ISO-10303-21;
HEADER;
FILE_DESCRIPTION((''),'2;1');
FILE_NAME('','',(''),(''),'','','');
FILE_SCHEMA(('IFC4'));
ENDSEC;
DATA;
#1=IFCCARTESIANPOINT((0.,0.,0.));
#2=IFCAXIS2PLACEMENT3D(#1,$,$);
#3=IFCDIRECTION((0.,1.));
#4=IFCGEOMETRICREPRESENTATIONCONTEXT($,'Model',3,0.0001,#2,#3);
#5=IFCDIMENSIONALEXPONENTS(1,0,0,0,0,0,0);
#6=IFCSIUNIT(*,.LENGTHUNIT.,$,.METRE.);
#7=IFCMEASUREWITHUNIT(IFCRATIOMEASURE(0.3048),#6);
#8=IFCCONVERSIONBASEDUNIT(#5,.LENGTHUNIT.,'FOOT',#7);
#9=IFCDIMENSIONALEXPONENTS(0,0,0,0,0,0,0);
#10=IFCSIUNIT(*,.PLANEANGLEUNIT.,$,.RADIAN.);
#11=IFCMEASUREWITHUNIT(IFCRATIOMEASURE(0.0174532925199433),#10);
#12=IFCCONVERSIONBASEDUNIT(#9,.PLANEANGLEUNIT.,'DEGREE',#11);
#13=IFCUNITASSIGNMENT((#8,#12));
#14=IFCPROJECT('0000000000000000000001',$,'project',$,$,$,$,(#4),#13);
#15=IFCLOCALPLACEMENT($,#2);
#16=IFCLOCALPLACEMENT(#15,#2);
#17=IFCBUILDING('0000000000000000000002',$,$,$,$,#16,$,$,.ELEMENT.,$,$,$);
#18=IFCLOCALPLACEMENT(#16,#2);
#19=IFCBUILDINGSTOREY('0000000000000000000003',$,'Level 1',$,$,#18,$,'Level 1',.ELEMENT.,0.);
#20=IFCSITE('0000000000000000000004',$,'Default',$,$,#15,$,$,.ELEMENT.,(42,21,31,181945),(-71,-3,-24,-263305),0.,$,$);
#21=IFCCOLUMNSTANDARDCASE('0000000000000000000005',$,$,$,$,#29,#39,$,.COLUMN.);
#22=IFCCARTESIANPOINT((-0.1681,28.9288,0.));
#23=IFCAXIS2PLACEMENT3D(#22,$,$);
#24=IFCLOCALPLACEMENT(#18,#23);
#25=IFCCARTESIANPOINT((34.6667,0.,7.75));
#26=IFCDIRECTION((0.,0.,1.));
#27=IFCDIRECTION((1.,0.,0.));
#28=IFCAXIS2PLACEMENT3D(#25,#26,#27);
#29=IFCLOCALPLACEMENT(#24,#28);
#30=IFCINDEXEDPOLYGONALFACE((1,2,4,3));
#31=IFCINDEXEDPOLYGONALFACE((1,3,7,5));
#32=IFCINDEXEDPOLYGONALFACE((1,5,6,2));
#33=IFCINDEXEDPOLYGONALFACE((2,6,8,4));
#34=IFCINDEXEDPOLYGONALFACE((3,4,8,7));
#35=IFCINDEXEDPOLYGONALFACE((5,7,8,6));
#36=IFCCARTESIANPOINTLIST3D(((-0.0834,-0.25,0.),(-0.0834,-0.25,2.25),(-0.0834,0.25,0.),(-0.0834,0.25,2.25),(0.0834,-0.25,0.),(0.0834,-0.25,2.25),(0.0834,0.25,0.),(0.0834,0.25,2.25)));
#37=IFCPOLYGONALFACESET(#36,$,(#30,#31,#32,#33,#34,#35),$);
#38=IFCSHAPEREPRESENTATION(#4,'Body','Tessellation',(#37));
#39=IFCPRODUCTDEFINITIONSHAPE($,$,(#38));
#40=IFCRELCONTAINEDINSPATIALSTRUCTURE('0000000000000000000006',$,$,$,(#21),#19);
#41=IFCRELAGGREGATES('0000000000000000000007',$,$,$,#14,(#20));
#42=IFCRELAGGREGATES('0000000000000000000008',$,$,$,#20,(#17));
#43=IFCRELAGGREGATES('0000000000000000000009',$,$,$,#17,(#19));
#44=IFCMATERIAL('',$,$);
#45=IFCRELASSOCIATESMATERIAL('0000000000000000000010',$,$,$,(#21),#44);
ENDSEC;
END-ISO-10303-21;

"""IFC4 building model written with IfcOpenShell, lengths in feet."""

from ifc_helpers import new_model, entity, si_unit, converted_unit, direction, frame, origin, place, context, project, spatial, rectangle, extrude, material, element, save


model = new_model("IFC4")

# Units and contexts
model_context = context("Model", 3, precision=0.0001, world=origin(), true_north=direction((0.0, 1.0)))
ifc_project = project(units=[converted_unit("LENGTHUNIT", "FOOT", entity("IfcRatioMeasure", 0.3048), si_unit("LENGTHUNIT", "METRE"), dimensions=[1, 0, 0, 0, 0, 0, 0]), converted_unit("PLANEANGLEUNIT", "DEGREE", entity("IfcRatioMeasure", 0.0174532925199433), si_unit("PLANEANGLEUNIT", "RADIAN"), dimensions=[0, 0, 0, 0, 0, 0, 0])], contexts=[model_context])

# Site, building, storey
site_placement = place(None, origin())
site = spatial("IfcSite", under=ifc_project, at=site_placement, Name="Default", CompositionType="ELEMENT", RefLatitude=(42, 21, 31, 181945), RefLongitude=(-71, -3, -24, -263305), RefElevation=0.0)
building_placement = place(site_placement, origin())
building = spatial("IfcBuilding", under=site, at=building_placement, CompositionType="ELEMENT")
storey_placement = place(building_placement, origin())
storey = spatial("IfcBuildingStorey", under=building, at=storey_placement, Name="Level 1", LongName="Level 1", CompositionType="ELEMENT", Elevation=0.0)

# Column
ifc_material_1 = material(Name="")
placement = place(storey_placement, frame((-0.1681, 28.9288, 0.0)))
for number, where, z_axis, x_axis in (
    (1, (34.6667, 0.0, 7.75), (0.0, 0.0, 1.0), (1.0, 0.0, 0.0)),
):
    element("IfcColumnStandardCase", number, at=place(placement, frame(where, z_axis=z_axis, x_axis=x_axis)), inside=storey, material=ifc_material_1, PredefinedType="COLUMN", context=model_context, shape_type="SweptSolid", body=[
        extrude(rectangle(XDim=0.1667, YDim=0.5), origin(), (0.0, 0.0, 1.0), 2.25),
    ])

save(model, "model.ifc")
